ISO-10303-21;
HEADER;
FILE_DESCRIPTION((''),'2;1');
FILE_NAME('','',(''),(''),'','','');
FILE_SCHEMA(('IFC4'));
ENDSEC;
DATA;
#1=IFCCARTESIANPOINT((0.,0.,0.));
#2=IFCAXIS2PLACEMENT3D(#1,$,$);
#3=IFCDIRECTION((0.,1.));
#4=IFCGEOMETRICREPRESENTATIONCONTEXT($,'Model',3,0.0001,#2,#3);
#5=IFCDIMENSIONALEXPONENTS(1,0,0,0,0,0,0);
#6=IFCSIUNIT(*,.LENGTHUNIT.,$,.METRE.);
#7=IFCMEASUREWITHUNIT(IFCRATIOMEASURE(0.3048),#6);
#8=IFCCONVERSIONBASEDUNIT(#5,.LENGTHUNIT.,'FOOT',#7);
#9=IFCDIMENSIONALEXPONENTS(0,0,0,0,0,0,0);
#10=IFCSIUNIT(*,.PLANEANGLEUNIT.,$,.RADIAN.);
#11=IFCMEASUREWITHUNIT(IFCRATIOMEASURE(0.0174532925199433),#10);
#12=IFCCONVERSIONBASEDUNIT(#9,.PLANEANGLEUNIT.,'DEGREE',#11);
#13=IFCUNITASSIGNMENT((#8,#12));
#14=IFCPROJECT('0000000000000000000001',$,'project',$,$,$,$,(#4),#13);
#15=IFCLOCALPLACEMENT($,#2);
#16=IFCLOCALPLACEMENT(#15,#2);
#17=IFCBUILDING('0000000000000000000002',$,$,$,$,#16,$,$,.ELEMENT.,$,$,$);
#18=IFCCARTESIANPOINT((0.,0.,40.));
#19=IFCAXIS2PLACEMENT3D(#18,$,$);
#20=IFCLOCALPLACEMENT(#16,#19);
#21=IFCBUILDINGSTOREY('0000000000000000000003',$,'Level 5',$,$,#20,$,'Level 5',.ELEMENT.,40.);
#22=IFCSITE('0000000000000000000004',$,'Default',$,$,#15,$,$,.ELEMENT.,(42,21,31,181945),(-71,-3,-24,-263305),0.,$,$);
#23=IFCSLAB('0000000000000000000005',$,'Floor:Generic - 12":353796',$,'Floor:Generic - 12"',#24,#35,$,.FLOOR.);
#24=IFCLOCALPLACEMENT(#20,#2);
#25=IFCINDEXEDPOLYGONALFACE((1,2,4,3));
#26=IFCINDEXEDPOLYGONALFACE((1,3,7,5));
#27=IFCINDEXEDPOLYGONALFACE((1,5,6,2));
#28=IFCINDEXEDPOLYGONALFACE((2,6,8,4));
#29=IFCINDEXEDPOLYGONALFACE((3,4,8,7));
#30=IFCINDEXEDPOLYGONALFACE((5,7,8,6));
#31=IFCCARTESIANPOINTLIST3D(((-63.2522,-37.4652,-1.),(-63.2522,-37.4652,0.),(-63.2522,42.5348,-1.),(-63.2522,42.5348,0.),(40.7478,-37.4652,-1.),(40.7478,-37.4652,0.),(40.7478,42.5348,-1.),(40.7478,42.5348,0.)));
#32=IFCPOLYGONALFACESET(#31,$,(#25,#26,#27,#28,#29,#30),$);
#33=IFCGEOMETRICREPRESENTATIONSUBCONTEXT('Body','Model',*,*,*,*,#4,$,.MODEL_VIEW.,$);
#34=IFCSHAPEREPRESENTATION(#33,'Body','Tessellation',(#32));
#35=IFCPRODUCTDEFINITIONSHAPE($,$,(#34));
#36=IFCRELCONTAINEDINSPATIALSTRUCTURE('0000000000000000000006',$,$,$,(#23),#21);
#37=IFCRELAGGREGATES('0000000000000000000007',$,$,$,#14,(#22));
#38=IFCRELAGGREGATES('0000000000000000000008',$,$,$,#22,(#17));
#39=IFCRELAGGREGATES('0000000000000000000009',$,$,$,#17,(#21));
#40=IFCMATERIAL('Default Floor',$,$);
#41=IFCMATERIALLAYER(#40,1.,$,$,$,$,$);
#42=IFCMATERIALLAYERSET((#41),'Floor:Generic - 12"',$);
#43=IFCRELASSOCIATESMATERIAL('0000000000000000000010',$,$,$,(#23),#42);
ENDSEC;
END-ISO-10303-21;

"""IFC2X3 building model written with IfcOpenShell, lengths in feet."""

from ifc_helpers import new_model, entity, si_unit, converted_unit, direction, frame, origin, origin_2d_with_axis, place, context, subcontext, project, spatial, rectangle, extrude, material, layer, layer_set, layer_usage, element, save


model = new_model("IFC2X3")

# Units and contexts
model_context = context("Model", 3, precision=0.0001, world=origin(), true_north=direction((0.0, 1.0)))
body_context = subcontext(model_context, "Body", "Model", "MODEL_VIEW")
ifc_project = project(units=[converted_unit("LENGTHUNIT", "FOOT", entity("IfcRatioMeasure", 0.3048), si_unit("LENGTHUNIT", "METRE"), dimensions=[1, 0, 0, 0, 0, 0, 0]), converted_unit("PLANEANGLEUNIT", "DEGREE", entity("IfcRatioMeasure", 0.0174532925199433), si_unit("PLANEANGLEUNIT", "RADIAN"), dimensions=[0, 0, 0, 0, 0, 0, 0])], contexts=[model_context])

# Site, building, storey
site_placement = place(None, origin())
site = spatial("IfcSite", under=ifc_project, at=site_placement, Name="Default", CompositionType="ELEMENT", RefLatitude=(42, 21, 31, 181945), RefLongitude=(-71, -3, -24, -263305), RefElevation=0.0)
building_placement = place(site_placement, origin())
building = spatial("IfcBuilding", under=site, at=building_placement, CompositionType="ELEMENT")
storey_placement = place(building_placement, frame((0.0, 0.0, 40.0)))
storey = spatial("IfcBuildingStorey", under=building, at=storey_placement, Name="Level 5", LongName="Level 5", CompositionType="ELEMENT", Elevation=40.0)

# Slab
ifc_material = material(Name="Default Floor")
ifc_layer = layer(ifc_material, 1.0)
ifc_layer_set = layer_set([ifc_layer], Name="Floor:Generic - 12\"")
ifc_layer_usage = layer_usage(ifc_layer_set, "AXIS3", "POSITIVE", 0.0)
slab_placement = place(storey_placement, origin())
element("IfcSlab", 1, at=slab_placement, inside=storey, material=ifc_layer_usage, Name="Floor:Generic - 12\":353796", ObjectType="Floor:Generic - 12\"", PredefinedType="FLOOR", context=body_context, shape_type="SweptSolid", body=[
    extrude(rectangle(XDim=80.0, YDim=104.0, at=origin_2d_with_axis()), frame((-11.2522, 2.5348, 0.0), z_axis=(0.0, 0.0, -1.0), x_axis=(0.0, 1.0, 0.0)), (0.0, 0.0, 1.0), 1.0),
])

save(model, "model.ifc")
